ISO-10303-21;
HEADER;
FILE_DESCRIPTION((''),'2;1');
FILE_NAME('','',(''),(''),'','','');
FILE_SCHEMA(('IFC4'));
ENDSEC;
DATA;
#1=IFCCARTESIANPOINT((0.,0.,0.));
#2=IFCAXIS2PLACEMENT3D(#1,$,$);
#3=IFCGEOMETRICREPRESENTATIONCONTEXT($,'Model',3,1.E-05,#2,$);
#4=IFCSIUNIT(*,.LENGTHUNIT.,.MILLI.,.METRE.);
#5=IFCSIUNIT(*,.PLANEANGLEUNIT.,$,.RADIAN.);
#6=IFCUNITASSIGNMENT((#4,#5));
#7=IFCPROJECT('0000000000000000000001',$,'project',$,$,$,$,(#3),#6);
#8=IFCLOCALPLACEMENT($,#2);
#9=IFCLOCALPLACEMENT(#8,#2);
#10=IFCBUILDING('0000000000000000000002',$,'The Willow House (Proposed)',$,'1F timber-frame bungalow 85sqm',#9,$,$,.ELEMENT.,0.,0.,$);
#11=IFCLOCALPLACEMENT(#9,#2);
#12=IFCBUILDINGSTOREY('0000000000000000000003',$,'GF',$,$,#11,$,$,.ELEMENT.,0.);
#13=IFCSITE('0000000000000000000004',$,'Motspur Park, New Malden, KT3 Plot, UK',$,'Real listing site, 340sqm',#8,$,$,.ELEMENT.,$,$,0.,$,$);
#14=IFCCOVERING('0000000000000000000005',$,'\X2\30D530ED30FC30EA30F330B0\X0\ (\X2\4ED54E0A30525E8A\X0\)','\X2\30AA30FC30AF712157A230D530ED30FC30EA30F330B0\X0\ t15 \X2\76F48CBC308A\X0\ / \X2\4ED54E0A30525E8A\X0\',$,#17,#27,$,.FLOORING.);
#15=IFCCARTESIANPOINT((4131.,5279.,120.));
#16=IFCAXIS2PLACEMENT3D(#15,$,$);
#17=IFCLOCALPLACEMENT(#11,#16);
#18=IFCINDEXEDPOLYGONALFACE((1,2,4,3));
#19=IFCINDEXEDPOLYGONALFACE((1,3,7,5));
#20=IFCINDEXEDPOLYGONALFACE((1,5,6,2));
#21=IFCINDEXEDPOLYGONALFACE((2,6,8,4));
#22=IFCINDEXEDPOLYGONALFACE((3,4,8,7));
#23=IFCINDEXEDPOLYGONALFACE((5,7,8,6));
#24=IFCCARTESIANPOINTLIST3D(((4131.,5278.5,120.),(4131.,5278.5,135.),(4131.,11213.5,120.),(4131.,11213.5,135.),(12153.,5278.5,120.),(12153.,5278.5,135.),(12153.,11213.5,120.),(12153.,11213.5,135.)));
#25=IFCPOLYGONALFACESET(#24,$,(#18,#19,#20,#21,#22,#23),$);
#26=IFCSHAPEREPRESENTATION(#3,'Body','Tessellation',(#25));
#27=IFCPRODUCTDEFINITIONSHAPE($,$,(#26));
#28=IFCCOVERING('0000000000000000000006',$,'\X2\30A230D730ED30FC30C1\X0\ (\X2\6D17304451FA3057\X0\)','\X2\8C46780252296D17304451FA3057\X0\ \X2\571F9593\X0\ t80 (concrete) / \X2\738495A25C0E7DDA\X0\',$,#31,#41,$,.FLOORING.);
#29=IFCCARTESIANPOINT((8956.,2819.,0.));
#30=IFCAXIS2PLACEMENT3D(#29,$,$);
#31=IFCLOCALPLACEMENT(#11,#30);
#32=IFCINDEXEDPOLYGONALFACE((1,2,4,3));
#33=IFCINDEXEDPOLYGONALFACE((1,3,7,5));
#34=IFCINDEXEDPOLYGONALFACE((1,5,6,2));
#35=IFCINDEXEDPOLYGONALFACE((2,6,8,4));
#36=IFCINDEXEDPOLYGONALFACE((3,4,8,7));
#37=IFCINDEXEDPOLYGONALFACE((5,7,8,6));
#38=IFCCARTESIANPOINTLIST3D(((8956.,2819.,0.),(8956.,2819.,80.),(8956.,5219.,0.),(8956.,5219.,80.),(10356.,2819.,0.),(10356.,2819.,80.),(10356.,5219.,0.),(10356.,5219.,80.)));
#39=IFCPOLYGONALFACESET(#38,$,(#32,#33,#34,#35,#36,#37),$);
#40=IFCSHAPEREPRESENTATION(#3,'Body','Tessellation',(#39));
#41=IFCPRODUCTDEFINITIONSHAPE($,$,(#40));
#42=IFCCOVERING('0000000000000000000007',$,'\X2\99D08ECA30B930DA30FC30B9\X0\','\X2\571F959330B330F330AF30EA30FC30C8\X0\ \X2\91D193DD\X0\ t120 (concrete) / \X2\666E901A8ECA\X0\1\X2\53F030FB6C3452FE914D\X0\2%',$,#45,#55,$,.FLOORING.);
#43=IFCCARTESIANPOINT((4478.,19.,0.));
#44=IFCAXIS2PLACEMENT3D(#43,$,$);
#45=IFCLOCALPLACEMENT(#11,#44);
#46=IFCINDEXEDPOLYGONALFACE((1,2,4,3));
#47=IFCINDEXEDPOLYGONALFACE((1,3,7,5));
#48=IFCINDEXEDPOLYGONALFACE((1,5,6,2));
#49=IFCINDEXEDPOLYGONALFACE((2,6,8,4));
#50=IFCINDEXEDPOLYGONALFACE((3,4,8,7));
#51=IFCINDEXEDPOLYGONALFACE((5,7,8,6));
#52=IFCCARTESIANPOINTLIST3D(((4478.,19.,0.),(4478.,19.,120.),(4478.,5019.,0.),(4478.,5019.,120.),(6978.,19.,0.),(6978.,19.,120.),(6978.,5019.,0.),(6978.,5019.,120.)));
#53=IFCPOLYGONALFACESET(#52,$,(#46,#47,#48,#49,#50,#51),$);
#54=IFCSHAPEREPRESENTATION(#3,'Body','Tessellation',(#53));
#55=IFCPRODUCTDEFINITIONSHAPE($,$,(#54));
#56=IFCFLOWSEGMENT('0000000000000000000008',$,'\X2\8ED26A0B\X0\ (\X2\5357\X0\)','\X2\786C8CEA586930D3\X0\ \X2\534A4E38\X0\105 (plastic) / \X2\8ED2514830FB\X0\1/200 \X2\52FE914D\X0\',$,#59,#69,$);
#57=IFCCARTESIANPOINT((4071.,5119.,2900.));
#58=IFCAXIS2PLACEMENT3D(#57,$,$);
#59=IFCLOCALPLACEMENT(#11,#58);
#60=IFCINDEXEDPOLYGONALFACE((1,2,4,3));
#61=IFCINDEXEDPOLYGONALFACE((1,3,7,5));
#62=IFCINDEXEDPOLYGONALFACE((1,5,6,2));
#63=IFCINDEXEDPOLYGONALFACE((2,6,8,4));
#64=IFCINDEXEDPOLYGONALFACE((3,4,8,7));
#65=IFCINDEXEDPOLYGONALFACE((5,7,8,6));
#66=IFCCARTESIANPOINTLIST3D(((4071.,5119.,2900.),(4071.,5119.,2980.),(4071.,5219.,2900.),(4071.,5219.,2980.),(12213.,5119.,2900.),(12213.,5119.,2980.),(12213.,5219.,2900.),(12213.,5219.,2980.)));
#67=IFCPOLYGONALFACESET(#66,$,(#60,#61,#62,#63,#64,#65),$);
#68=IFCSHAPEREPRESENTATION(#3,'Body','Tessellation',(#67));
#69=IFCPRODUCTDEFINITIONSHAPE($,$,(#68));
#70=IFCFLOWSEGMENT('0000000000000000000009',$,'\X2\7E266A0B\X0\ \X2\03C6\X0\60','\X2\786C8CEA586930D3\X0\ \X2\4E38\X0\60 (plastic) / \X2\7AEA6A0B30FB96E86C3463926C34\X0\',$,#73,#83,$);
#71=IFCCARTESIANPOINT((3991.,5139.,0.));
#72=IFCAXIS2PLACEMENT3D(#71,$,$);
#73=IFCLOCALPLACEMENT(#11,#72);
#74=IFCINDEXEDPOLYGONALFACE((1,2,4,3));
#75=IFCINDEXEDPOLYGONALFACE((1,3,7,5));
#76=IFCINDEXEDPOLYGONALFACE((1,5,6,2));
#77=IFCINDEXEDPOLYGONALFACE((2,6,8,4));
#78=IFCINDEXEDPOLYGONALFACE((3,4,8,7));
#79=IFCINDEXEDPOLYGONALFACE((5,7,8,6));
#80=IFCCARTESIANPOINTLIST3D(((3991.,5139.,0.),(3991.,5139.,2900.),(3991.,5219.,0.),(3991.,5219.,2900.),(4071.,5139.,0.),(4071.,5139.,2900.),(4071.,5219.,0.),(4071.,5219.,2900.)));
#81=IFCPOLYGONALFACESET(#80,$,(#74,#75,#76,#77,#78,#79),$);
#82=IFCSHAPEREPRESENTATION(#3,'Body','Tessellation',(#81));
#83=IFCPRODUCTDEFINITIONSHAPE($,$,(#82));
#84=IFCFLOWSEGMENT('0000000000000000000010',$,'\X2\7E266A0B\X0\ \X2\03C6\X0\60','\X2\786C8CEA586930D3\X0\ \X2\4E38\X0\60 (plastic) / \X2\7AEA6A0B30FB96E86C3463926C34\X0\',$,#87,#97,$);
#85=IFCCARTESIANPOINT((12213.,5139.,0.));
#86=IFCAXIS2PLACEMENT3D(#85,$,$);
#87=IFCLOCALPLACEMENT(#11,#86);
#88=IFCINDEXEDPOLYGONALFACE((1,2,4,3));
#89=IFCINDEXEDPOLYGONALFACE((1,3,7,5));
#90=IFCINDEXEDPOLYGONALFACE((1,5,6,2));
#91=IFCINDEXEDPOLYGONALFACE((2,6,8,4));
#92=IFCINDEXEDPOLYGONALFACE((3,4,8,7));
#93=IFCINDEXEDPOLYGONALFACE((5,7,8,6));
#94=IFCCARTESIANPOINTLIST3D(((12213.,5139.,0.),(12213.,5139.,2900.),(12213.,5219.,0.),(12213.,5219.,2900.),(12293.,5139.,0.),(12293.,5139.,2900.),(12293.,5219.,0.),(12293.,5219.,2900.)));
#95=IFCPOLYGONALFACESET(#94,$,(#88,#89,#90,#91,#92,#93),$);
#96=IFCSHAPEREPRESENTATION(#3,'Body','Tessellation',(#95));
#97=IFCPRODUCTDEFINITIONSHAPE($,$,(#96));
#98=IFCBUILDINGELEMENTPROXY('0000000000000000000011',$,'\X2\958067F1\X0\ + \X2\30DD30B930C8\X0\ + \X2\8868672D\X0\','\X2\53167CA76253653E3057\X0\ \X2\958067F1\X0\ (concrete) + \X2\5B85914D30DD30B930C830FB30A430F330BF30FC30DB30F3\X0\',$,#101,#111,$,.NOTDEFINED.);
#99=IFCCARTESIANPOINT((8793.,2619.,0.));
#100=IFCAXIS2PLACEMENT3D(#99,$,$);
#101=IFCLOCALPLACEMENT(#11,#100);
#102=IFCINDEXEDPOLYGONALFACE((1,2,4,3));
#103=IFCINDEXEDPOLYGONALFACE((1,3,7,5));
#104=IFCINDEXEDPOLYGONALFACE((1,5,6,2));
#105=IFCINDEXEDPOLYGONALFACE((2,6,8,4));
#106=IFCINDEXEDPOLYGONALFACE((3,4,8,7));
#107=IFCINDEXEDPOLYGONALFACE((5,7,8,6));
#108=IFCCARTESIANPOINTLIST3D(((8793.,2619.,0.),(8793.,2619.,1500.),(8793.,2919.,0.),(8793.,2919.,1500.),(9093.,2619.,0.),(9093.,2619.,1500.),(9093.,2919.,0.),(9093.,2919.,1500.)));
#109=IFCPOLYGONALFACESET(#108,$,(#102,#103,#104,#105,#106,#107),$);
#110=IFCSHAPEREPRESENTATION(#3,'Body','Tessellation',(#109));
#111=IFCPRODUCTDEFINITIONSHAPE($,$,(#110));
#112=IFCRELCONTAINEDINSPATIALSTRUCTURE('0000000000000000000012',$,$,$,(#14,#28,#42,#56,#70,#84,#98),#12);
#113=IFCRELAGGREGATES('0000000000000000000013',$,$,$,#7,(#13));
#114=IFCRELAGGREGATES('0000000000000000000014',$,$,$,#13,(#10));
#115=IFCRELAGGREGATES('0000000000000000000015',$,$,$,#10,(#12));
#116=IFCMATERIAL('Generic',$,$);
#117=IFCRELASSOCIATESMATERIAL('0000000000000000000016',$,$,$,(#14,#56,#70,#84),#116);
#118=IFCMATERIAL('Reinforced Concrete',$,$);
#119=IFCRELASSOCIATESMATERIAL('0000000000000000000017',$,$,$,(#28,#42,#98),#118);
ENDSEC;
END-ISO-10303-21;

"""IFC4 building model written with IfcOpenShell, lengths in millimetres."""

from ifc_helpers import new_model, si_unit, frame, frame_2d, origin, place, context, project, spatial, rectangle, extrude, material, element, save


model = new_model("IFC4")

# Units and contexts
model_context = context("Model", 3, precision=1e-05, world=origin())
ifc_project = project(units=[si_unit("LENGTHUNIT", "METRE", prefix="MILLI"), si_unit("PLANEANGLEUNIT", "RADIAN")], contexts=[model_context])

# Site, building, storey
site_placement = place(None, origin())
site = spatial("IfcSite", under=ifc_project, at=site_placement, Name="Motspur Park, New Malden, KT3 Plot, UK", ObjectType="Real listing site, 340sqm", CompositionType="ELEMENT", RefElevation=0.0)
building_placement = place(site_placement, origin())
building = spatial("IfcBuilding", under=site, at=building_placement, Name="The Willow House (Proposed)", ObjectType="1F timber-frame bungalow 85sqm", CompositionType="ELEMENT", ElevationOfRefHeight=0.0, ElevationOfTerrain=0.0)
storey_placement = place(building_placement, origin())
storey = spatial("IfcBuildingStorey", under=building, at=storey_placement, Name="GF", CompositionType="ELEMENT", Elevation=0.0)

# Shared definitions
ifc_material_1 = material(Name="Reinforced Concrete")

# Coverings
ifc_material_2 = material(Name="Generic")
covering_1_placement = place(storey_placement, frame((4131.0, 5279.0, 120.0)))
element("IfcCovering", 1, at=covering_1_placement, inside=storey, material=ifc_material_2, Name="フローリング (仕上げ床)", Description="オーク無垢フローリング t15 直貼り / 仕上げ床", PredefinedType="FLOORING", context=model_context, shape_type="SweptSolid", body=[
    extrude(rectangle(XDim=8022.0, YDim=5935.0, at=frame_2d((4011.0, 2967.0))), frame((4131.0, 5279.0, 120.0)), (0.0, 0.0, 1.0), 15.0),
])
covering_2_placement = place(storey_placement, frame((8956.0, 2819.0, 0.0)))
element("IfcCovering", 2, at=covering_2_placement, inside=storey, material=ifc_material_1, Name="アプローチ (洗い出し)", Description="豆砂利洗い出し 土間 t80 (concrete) / 玄関導線", PredefinedType="FLOORING", context=model_context, shape_type="SweptSolid", body=[
    extrude(rectangle(XDim=1400.0, YDim=2400.0, at=frame_2d((700.0, 1200.0))), frame((8956.0, 2819.0, 0.0)), (0.0, 0.0, 1.0), 80.0),
])
covering_3_placement = place(storey_placement, frame((4478.0, 19.0, 0.0)))
element("IfcCovering", 3, at=covering_3_placement, inside=storey, material=ifc_material_1, Name="駐車スペース", Description="土間コンクリート 金鏝 t120 (concrete) / 普通車1台・水勾配2%", PredefinedType="FLOORING", context=model_context, shape_type="SweptSolid", body=[
    extrude(rectangle(XDim=2500.0, YDim=5000.0, at=frame_2d((1250.0, 2500.0))), frame((4478.0, 19.0, 0.0)), (0.0, 0.0, 1.0), 120.0),
])

# Flow segments
flow_segment_1_placement = place(storey_placement, frame((4071.0, 5119.0, 2900.0)))
element("IfcFlowSegment", 4, at=flow_segment_1_placement, inside=storey, material=ifc_material_2, Name="軒樋 (南)", Description="硬質塩ビ 半丸105 (plastic) / 軒先・1/200 勾配", context=model_context, shape_type="SweptSolid", body=[
    extrude(rectangle(XDim=8142.0, YDim=100.0, at=frame_2d((4071.0, 50.0))), frame((4071.0, 5119.0, 2900.0)), (0.0, 0.0, 1.0), 80.0),
])
flow_segment_2_placement = place(storey_placement, frame((3991.0, 5139.0, 0.0)))
element("IfcFlowSegment", 5, at=flow_segment_2_placement, inside=storey, material=ifc_material_2, Name="縦樋 φ60", Description="硬質塩ビ 丸60 (plastic) / 竪樋・雨水排水", context=model_context, shape_type="SweptSolid", body=[
    extrude(rectangle(XDim=80.0, YDim=80.0, at=frame_2d((40.0, 40.0))), frame((3991.0, 5139.0, 0.0)), (0.0, 0.0, 1.0), 2900.0),
])
flow_segment_3_placement = place(storey_placement, frame((12213.0, 5139.0, 0.0)))
element("IfcFlowSegment", 6, at=flow_segment_3_placement, inside=storey, material=ifc_material_2, Name="縦樋 φ60", Description="硬質塩ビ 丸60 (plastic) / 竪樋・雨水排水", context=model_context, shape_type="SweptSolid", body=[
    extrude(rectangle(XDim=80.0, YDim=80.0, at=frame_2d((40.0, 40.0))), frame((12213.0, 5139.0, 0.0)), (0.0, 0.0, 1.0), 2900.0),
])

# Building element proxy
proxy_placement = place(storey_placement, frame((8793.0, 2619.0, 0.0)))
element("IfcBuildingElementProxy", 7, at=proxy_placement, inside=storey, material=ifc_material_1, Name="門柱 + ポスト + 表札", Description="化粧打放し 門柱 (concrete) + 宅配ポスト・インターホン", PredefinedType="NOTDEFINED", context=model_context, shape_type="SweptSolid", body=[
    extrude(rectangle(XDim=300.0, YDim=300.0, at=frame_2d((150.0, 150.0))), frame((8793.0, 2619.0, 0.0)), (0.0, 0.0, 1.0), 1500.0),
])

save(model, "model.ifc")
